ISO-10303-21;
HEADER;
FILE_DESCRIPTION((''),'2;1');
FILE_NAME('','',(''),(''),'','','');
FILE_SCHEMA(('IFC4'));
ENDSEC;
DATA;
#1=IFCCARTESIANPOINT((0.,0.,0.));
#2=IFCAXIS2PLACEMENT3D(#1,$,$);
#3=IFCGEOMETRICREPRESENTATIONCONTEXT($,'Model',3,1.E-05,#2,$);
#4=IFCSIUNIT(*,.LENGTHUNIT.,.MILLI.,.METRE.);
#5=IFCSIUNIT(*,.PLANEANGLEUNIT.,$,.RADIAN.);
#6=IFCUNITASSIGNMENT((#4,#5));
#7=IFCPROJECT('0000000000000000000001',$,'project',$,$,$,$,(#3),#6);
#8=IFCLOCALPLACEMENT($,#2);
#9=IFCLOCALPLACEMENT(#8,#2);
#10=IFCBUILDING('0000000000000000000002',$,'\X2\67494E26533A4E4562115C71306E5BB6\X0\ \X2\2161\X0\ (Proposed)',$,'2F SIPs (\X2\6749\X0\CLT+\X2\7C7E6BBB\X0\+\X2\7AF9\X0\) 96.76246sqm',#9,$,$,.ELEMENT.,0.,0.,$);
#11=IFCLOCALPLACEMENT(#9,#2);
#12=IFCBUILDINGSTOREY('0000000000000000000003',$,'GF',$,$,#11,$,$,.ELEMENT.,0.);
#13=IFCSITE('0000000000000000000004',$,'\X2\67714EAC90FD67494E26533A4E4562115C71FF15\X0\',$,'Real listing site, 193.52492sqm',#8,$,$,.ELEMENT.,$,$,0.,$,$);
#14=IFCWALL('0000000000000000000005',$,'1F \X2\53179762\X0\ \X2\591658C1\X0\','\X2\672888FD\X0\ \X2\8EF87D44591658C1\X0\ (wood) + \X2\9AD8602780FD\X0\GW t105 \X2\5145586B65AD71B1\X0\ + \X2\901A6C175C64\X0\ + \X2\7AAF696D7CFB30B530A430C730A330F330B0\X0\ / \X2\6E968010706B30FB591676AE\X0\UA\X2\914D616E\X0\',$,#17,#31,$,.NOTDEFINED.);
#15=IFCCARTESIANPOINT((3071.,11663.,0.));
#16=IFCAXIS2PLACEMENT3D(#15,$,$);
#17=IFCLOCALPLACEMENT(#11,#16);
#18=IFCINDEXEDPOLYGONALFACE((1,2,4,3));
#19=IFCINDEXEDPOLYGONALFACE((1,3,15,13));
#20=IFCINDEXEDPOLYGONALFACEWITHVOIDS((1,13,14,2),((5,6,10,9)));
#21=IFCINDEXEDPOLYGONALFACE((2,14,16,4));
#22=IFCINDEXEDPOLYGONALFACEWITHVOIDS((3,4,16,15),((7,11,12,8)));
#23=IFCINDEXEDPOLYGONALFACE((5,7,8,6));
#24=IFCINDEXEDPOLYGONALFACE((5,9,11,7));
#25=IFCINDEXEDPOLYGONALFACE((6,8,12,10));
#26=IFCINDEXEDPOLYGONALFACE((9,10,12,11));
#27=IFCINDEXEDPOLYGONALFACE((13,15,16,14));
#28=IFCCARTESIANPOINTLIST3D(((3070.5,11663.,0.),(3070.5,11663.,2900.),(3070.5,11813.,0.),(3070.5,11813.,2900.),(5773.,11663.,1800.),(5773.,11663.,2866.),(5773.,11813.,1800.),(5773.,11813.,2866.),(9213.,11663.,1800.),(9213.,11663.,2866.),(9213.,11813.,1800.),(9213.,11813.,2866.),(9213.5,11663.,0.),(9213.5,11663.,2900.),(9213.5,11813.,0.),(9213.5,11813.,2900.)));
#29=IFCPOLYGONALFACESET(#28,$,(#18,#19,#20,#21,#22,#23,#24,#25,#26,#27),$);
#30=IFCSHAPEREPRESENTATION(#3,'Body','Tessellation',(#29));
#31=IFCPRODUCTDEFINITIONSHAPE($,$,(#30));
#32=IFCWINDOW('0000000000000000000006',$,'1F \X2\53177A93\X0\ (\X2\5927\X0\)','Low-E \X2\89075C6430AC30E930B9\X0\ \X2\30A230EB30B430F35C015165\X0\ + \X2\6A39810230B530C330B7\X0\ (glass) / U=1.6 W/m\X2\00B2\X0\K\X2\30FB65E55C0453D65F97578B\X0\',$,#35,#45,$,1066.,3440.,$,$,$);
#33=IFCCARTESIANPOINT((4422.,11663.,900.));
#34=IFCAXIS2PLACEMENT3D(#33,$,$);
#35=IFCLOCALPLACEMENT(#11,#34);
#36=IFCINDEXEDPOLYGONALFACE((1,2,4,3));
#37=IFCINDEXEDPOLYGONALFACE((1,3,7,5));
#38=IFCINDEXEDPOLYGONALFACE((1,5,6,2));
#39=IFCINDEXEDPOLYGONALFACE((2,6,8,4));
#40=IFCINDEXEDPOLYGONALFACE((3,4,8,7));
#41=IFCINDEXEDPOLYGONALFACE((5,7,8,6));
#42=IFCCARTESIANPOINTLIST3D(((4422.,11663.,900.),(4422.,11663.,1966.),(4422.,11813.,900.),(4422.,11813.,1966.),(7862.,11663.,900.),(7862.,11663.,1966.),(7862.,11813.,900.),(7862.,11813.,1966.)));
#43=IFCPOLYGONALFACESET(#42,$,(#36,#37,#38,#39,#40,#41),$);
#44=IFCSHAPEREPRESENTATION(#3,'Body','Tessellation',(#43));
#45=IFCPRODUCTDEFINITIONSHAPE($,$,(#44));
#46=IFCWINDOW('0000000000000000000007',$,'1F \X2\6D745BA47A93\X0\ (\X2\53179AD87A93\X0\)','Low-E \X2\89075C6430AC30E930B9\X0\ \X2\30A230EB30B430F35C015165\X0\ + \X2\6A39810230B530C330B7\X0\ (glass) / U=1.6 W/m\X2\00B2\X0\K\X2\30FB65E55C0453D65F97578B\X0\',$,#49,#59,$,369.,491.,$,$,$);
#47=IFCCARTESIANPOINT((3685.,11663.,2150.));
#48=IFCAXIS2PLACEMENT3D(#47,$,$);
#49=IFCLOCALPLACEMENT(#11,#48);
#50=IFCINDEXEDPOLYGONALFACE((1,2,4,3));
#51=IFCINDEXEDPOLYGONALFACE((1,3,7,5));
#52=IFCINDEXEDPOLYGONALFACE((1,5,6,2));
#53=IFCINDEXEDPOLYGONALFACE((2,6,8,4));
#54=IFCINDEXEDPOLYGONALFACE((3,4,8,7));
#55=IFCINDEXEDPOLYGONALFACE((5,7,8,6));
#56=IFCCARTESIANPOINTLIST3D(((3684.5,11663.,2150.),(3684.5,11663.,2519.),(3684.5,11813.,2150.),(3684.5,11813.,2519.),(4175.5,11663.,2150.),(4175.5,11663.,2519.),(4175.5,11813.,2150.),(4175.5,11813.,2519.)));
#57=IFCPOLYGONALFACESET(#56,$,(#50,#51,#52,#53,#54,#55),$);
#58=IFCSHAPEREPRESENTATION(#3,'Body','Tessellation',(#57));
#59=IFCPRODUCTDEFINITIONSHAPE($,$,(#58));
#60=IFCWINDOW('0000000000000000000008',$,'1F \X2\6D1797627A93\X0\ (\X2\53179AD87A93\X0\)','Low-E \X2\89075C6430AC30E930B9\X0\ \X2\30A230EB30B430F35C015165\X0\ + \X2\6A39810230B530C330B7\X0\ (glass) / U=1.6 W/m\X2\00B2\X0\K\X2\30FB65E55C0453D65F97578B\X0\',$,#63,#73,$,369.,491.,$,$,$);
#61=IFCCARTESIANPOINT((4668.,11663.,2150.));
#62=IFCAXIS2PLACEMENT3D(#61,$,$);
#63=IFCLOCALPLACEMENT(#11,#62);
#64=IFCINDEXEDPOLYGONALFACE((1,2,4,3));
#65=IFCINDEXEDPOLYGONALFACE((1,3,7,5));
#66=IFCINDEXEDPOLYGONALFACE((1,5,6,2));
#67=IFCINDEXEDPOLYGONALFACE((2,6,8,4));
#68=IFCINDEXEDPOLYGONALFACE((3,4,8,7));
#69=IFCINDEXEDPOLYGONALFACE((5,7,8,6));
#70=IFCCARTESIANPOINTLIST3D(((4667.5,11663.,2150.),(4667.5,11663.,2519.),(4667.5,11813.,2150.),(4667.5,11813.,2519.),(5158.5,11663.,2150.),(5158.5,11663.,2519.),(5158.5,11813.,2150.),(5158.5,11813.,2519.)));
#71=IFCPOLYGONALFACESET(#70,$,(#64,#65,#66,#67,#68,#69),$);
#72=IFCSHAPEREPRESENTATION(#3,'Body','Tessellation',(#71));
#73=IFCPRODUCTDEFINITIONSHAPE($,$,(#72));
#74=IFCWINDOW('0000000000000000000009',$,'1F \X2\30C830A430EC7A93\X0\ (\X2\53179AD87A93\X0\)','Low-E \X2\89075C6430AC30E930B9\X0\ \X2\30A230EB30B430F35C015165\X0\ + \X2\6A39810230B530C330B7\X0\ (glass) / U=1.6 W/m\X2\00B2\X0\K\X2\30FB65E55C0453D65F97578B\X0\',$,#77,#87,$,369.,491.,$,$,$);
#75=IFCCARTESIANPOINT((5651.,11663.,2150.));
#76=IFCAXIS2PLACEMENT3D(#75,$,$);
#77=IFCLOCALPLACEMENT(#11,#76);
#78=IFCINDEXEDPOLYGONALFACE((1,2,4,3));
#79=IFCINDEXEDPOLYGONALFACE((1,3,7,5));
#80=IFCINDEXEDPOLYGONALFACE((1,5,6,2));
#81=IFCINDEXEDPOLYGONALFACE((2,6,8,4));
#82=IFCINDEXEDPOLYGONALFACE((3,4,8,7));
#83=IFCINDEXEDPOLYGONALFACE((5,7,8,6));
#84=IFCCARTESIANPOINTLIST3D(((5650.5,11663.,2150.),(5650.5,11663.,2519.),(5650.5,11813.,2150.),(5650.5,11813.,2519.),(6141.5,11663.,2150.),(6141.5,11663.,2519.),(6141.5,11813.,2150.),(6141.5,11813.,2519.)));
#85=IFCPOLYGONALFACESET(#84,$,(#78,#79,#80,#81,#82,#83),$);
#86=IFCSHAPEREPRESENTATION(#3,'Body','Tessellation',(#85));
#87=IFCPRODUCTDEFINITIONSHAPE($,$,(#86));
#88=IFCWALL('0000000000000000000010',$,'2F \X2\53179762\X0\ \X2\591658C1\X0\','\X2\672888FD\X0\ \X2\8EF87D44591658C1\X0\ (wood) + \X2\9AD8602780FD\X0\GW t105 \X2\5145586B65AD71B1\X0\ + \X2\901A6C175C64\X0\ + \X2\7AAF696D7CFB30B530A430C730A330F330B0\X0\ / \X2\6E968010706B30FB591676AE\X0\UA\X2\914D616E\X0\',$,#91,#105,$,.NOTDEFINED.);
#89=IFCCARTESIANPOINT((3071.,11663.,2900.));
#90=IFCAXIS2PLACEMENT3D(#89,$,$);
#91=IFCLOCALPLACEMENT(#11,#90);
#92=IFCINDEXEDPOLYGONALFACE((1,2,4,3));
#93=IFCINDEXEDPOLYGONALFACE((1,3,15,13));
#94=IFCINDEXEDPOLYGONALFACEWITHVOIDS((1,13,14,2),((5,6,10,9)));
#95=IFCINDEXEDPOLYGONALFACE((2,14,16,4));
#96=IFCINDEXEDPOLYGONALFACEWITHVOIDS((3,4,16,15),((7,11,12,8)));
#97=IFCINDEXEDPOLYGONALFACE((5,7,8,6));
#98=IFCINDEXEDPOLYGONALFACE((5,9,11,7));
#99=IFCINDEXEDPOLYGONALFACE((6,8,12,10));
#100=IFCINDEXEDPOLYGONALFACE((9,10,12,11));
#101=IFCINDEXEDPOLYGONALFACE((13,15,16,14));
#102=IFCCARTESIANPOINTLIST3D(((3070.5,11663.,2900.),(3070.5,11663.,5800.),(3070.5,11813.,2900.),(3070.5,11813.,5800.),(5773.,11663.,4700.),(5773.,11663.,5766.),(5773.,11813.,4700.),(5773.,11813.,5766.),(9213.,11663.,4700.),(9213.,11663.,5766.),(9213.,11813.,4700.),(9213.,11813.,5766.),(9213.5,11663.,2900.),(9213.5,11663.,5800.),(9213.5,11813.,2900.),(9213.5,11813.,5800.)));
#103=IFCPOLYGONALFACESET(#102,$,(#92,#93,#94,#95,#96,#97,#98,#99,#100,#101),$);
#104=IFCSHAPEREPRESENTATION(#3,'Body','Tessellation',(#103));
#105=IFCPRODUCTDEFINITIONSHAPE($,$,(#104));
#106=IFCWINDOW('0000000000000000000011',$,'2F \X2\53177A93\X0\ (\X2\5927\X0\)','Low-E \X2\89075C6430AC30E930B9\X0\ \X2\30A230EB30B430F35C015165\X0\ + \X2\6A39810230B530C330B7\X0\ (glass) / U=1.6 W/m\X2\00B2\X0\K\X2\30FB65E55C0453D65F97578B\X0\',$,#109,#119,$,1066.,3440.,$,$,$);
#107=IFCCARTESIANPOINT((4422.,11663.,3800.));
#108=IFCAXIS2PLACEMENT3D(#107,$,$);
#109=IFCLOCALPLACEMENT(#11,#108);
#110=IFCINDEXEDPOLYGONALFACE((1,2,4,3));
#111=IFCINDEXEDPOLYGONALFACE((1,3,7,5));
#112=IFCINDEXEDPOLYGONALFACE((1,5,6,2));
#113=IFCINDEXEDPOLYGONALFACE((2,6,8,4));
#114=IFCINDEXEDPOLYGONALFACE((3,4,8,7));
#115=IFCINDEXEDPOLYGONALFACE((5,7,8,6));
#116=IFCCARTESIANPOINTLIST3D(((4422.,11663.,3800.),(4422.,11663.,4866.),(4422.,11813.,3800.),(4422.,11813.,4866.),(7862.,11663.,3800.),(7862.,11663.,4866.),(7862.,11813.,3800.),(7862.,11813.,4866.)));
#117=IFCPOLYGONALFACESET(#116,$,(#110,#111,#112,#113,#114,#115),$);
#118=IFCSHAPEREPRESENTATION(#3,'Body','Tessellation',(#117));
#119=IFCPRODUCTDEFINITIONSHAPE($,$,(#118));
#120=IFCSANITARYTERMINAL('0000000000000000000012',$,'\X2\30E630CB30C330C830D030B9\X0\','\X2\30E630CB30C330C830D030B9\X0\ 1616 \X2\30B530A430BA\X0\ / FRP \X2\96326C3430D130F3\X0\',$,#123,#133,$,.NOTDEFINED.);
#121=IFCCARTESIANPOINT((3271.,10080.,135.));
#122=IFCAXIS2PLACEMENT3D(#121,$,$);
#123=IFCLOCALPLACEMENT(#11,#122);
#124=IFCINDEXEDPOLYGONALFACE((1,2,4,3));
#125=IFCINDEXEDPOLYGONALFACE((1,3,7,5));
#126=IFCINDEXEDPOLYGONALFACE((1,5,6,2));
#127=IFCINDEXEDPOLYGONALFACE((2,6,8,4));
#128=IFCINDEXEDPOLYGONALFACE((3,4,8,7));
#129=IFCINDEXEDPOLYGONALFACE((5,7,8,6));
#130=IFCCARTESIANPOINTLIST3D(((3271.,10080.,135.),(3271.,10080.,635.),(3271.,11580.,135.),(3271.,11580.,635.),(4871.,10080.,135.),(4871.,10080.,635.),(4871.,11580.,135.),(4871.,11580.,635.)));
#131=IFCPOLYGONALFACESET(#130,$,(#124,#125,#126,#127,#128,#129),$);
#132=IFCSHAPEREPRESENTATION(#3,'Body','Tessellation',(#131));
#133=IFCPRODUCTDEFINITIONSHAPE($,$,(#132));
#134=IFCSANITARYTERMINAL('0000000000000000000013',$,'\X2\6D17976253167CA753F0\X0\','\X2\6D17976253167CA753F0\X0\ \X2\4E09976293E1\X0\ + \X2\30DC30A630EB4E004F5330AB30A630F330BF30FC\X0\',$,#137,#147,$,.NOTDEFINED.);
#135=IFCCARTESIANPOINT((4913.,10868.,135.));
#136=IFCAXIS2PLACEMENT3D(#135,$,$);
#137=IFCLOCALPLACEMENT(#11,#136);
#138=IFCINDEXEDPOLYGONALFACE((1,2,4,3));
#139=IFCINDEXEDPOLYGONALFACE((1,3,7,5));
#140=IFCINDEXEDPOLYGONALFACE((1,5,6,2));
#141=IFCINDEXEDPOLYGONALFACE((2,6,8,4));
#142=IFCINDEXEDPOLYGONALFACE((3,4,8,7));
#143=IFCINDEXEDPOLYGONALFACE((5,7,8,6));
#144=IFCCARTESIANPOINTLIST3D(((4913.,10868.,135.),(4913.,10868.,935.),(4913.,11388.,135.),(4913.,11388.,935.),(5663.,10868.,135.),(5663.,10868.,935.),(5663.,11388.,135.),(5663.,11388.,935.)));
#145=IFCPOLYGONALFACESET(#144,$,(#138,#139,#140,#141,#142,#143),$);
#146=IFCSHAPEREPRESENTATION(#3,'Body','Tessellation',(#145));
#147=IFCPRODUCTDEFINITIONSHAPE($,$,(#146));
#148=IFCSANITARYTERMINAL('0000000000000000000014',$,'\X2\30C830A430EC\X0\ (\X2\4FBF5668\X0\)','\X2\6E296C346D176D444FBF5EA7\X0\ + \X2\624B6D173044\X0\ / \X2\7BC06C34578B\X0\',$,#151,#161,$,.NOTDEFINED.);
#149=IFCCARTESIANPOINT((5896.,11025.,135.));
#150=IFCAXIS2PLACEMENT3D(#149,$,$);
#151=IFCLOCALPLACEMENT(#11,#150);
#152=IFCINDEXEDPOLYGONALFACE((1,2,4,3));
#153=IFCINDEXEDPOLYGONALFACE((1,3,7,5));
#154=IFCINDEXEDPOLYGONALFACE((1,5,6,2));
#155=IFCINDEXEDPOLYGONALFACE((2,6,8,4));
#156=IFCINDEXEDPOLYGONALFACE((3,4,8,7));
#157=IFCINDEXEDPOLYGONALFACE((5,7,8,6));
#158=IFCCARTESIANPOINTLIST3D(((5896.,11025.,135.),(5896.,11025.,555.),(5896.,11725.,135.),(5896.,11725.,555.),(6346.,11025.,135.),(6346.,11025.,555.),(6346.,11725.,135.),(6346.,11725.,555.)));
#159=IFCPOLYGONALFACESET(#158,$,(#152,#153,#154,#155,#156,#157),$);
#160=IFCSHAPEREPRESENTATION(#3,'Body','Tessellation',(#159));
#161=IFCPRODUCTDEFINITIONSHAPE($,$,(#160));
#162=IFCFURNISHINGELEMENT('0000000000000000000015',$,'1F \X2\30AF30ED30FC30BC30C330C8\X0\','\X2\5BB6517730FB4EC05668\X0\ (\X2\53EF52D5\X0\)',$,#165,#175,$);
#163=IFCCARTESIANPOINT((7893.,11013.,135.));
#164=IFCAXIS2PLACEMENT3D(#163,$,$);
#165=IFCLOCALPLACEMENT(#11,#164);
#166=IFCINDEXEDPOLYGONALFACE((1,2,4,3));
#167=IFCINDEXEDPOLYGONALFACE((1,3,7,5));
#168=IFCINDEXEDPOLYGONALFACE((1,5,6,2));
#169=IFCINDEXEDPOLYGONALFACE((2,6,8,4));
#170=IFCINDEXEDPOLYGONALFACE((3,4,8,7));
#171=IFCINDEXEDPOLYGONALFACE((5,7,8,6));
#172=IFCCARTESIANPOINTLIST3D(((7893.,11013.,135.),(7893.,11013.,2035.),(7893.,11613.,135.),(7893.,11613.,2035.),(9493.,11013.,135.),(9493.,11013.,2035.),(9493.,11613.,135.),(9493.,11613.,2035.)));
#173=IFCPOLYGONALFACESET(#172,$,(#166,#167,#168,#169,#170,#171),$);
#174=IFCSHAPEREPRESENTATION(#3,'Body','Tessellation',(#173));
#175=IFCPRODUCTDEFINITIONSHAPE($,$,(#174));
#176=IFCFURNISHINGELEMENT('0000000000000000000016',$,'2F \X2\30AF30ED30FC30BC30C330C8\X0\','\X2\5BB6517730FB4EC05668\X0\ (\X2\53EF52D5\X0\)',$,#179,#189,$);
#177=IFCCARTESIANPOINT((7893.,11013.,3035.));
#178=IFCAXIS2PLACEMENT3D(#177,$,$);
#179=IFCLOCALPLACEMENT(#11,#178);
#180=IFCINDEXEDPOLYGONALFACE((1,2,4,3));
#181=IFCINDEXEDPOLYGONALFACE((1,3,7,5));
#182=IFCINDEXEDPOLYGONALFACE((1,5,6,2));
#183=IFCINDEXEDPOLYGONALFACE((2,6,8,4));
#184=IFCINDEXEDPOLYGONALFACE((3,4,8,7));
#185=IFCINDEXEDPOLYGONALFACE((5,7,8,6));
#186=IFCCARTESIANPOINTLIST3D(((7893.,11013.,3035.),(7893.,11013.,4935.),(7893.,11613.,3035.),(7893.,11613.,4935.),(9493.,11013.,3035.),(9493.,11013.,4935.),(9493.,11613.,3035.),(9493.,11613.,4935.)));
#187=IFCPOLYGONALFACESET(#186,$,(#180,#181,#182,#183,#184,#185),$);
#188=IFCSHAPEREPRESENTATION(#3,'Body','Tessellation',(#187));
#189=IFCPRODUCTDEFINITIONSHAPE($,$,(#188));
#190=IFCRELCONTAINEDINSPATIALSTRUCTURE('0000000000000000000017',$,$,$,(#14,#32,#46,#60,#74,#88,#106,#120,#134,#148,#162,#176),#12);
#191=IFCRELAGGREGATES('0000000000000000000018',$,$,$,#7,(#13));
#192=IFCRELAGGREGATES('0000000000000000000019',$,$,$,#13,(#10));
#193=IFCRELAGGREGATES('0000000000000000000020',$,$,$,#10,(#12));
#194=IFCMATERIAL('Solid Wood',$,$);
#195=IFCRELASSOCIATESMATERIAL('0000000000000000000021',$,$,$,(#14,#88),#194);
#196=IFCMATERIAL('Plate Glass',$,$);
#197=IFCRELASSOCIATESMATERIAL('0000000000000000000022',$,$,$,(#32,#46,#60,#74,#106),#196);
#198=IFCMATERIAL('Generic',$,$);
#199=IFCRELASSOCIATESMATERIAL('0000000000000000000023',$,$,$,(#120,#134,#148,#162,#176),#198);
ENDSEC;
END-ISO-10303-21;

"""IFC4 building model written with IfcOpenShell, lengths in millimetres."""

from ifc_helpers import new_model, si_unit, frame, frame_2d, origin, place, context, project, spatial, rectangle, extrude, material, element, fill, save


model = new_model("IFC4")

# Units and contexts
model_context = context("Model", 3, precision=1e-05, world=origin())
ifc_project = project(units=[si_unit("LENGTHUNIT", "METRE", prefix="MILLI"), si_unit("PLANEANGLEUNIT", "RADIAN")], contexts=[model_context])

# Site, building, storey
site_placement = place(None, origin())
site = spatial("IfcSite", under=ifc_project, at=site_placement, Name="東京都杉並区久我山５", ObjectType="Real listing site, 193.52492sqm", CompositionType="ELEMENT", RefElevation=0.0)
building_placement = place(site_placement, origin())
building = spatial("IfcBuilding", under=site, at=building_placement, Name="杉並区久我山の家 Ⅱ (Proposed)", ObjectType="2F SIPs (杉CLT+籾殻+竹) 96.76246sqm", CompositionType="ELEMENT", ElevationOfRefHeight=0.0, ElevationOfTerrain=0.0)
storey_placement = place(building_placement, origin())
storey = spatial("IfcBuildingStorey", under=building, at=storey_placement, Name="GF", CompositionType="ELEMENT", Elevation=0.0)

# Wall, openings, windows
ifc_material_1 = material(Name="Solid Wood")
wall_1_placement = place(storey_placement, frame((3071.0, 11663.0, 0.0)))
wall_1 = element("IfcWall", 1, at=wall_1_placement, inside=storey, material=ifc_material_1, Name="1F 北面 外壁", Description="木製 軸組外壁 (wood) + 高性能GW t105 充填断熱 + 通気層 + 窯業系サイディング / 準耐火・外皮UA配慮", PredefinedType="NOTDEFINED", context=model_context, shape_type="SweptSolid", body=[
    extrude(rectangle(XDim=6143.0, YDim=150.0, at=frame_2d((3071.0, 75.0))), frame((3071.0, 11663.0, 0.0)), (0.0, 0.0, 1.0), 2900.0),
])
opening_1_placement = place(storey_placement, frame((4422.0, 11663.0, 900.0)))
opening_1 = element("IfcOpeningElement", 2, at=opening_1_placement, cuts=wall_1, PredefinedType="NOTDEFINED", context=model_context, shape_type="SweptSolid", body=[
    extrude(rectangle(XDim=3440.0, YDim=150.0, at=frame_2d((1720.0, 75.0))), frame((4422.0, 11663.0, 900.0)), (0.0, 0.0, 1.0), 1066.0),
])
opening_2_placement = place(storey_placement, frame((3685.0, 11663.0, 2150.0)))
opening_2 = element("IfcOpeningElement", 3, at=opening_2_placement, cuts=wall_1, PredefinedType="NOTDEFINED", context=model_context, shape_type="SweptSolid", body=[
    extrude(rectangle(XDim=491.0, YDim=150.0, at=frame_2d((245.0, 75.0))), frame((3685.0, 11663.0, 2150.0)), (0.0, 0.0, 1.0), 369.0),
])
opening_3_placement = place(storey_placement, frame((4668.0, 11663.0, 2150.0)))
opening_3 = element("IfcOpeningElement", 4, at=opening_3_placement, cuts=wall_1, PredefinedType="NOTDEFINED", context=model_context, shape_type="SweptSolid", body=[
    extrude(rectangle(XDim=491.0, YDim=150.0, at=frame_2d((245.0, 75.0))), frame((4668.0, 11663.0, 2150.0)), (0.0, 0.0, 1.0), 369.0),
])
opening_4_placement = place(storey_placement, frame((5651.0, 11663.0, 2150.0)))
opening_4 = element("IfcOpeningElement", 5, at=opening_4_placement, cuts=wall_1, PredefinedType="NOTDEFINED", context=model_context, shape_type="SweptSolid", body=[
    extrude(rectangle(XDim=491.0, YDim=150.0, at=frame_2d((245.0, 75.0))), frame((5651.0, 11663.0, 2150.0)), (0.0, 0.0, 1.0), 369.0),
])
ifc_material_2 = material(Name="Plate Glass")
window_1_placement = place(storey_placement, frame((4422.0, 11663.0, 900.0)))
window_1 = element("IfcWindow", 6, at=window_1_placement, inside=storey, material=ifc_material_2, Name="1F 北窓 (大)", Description="Low-E 複層ガラス アルゴン封入 + 樹脂サッシ (glass) / U=1.6 W/m²K・日射取得型", OverallHeight=1066.0, OverallWidth=3440.0, context=model_context, shape_type="SweptSolid", body=[
    extrude(rectangle(XDim=3440.0, YDim=150.0, at=frame_2d((1720.0, 75.0))), frame((4422.0, 11663.0, 900.0)), (0.0, 0.0, 1.0), 1066.0),
])
fill(opening_1, window_1)
window_2_placement = place(storey_placement, frame((3685.0, 11663.0, 2150.0)))
window_2 = element("IfcWindow", 7, at=window_2_placement, inside=storey, material=ifc_material_2, Name="1F 浴室窓 (北高窓)", Description="Low-E 複層ガラス アルゴン封入 + 樹脂サッシ (glass) / U=1.6 W/m²K・日射取得型", OverallHeight=369.0, OverallWidth=491.0, context=model_context, shape_type="SweptSolid", body=[
    extrude(rectangle(XDim=491.0, YDim=150.0, at=frame_2d((245.0, 75.0))), frame((3685.0, 11663.0, 2150.0)), (0.0, 0.0, 1.0), 369.0),
])
fill(opening_2, window_2)
window_3_placement = place(storey_placement, frame((4668.0, 11663.0, 2150.0)))
window_3 = element("IfcWindow", 8, at=window_3_placement, inside=storey, material=ifc_material_2, Name="1F 洗面窓 (北高窓)", Description="Low-E 複層ガラス アルゴン封入 + 樹脂サッシ (glass) / U=1.6 W/m²K・日射取得型", OverallHeight=369.0, OverallWidth=491.0, context=model_context, shape_type="SweptSolid", body=[
    extrude(rectangle(XDim=491.0, YDim=150.0, at=frame_2d((245.0, 75.0))), frame((4668.0, 11663.0, 2150.0)), (0.0, 0.0, 1.0), 369.0),
])
fill(opening_3, window_3)
window_4_placement = place(storey_placement, frame((5651.0, 11663.0, 2150.0)))
window_4 = element("IfcWindow", 9, at=window_4_placement, inside=storey, material=ifc_material_2, Name="1F トイレ窓 (北高窓)", Description="Low-E 複層ガラス アルゴン封入 + 樹脂サッシ (glass) / U=1.6 W/m²K・日射取得型", OverallHeight=369.0, OverallWidth=491.0, context=model_context, shape_type="SweptSolid", body=[
    extrude(rectangle(XDim=491.0, YDim=150.0, at=frame_2d((245.0, 75.0))), frame((5651.0, 11663.0, 2150.0)), (0.0, 0.0, 1.0), 369.0),
])
fill(opening_4, window_4)

# Wall, opening, window
wall_2_placement = place(storey_placement, frame((3071.0, 11663.0, 2900.0)))
wall_2 = element("IfcWall", 10, at=wall_2_placement, inside=storey, material=ifc_material_1, Name="2F 北面 外壁", Description="木製 軸組外壁 (wood) + 高性能GW t105 充填断熱 + 通気層 + 窯業系サイディング / 準耐火・外皮UA配慮", PredefinedType="NOTDEFINED", context=model_context, shape_type="SweptSolid", body=[
    extrude(rectangle(XDim=6143.0, YDim=150.0, at=frame_2d((3071.0, 75.0))), frame((3071.0, 11663.0, 2900.0)), (0.0, 0.0, 1.0), 2900.0),
])
opening_5_placement = place(storey_placement, frame((4422.0, 11663.0, 3800.0)))
opening_5 = element("IfcOpeningElement", 11, at=opening_5_placement, cuts=wall_2, PredefinedType="NOTDEFINED", context=model_context, shape_type="SweptSolid", body=[
    extrude(rectangle(XDim=3440.0, YDim=150.0, at=frame_2d((1720.0, 75.0))), frame((4422.0, 11663.0, 3800.0)), (0.0, 0.0, 1.0), 1066.0),
])
window_5_placement = place(storey_placement, frame((4422.0, 11663.0, 3800.0)))
window_5 = element("IfcWindow", 12, at=window_5_placement, inside=storey, material=ifc_material_2, Name="2F 北窓 (大)", Description="Low-E 複層ガラス アルゴン封入 + 樹脂サッシ (glass) / U=1.6 W/m²K・日射取得型", OverallHeight=1066.0, OverallWidth=3440.0, context=model_context, shape_type="SweptSolid", body=[
    extrude(rectangle(XDim=3440.0, YDim=150.0, at=frame_2d((1720.0, 75.0))), frame((4422.0, 11663.0, 3800.0)), (0.0, 0.0, 1.0), 1066.0),
])
fill(opening_5, window_5)

# Sanitary terminals
ifc_material_3 = material(Name="Generic")
sanitary_terminal_1_placement = place(storey_placement, frame((3271.0, 10080.0, 135.0)))
element("IfcSanitaryTerminal", 13, at=sanitary_terminal_1_placement, inside=storey, material=ifc_material_3, Name="ユニットバス", Description="ユニットバス 1616 サイズ / FRP 防水パン", PredefinedType="NOTDEFINED", context=model_context, shape_type="SweptSolid", body=[
    extrude(rectangle(XDim=1600.0, YDim=1500.0, at=frame_2d((800.0, 750.0))), frame((3271.0, 10080.0, 135.0)), (0.0, 0.0, 1.0), 500.0),
])
sanitary_terminal_2_placement = place(storey_placement, frame((4913.0, 10868.0, 135.0)))
element("IfcSanitaryTerminal", 14, at=sanitary_terminal_2_placement, inside=storey, material=ifc_material_3, Name="洗面化粧台", Description="洗面化粧台 三面鏡 + ボウル一体カウンター", PredefinedType="NOTDEFINED", context=model_context, shape_type="SweptSolid", body=[
    extrude(rectangle(XDim=750.0, YDim=520.0, at=frame_2d((375.0, 260.0))), frame((4913.0, 10868.0, 135.0)), (0.0, 0.0, 1.0), 800.0),
])
sanitary_terminal_3_placement = place(storey_placement, frame((5896.0, 11025.0, 135.0)))
element("IfcSanitaryTerminal", 15, at=sanitary_terminal_3_placement, inside=storey, material=ifc_material_3, Name="トイレ (便器)", Description="温水洗浄便座 + 手洗い / 節水型", PredefinedType="NOTDEFINED", context=model_context, shape_type="SweptSolid", body=[
    extrude(rectangle(XDim=450.0, YDim=700.0, at=frame_2d((225.0, 350.0))), frame((5896.0, 11025.0, 135.0)), (0.0, 0.0, 1.0), 420.0),
])

# Furnishing elements
furnishing_1_placement = place(storey_placement, frame((7893.0, 11013.0, 135.0)))
element("IfcFurnishingElement", 16, at=furnishing_1_placement, inside=storey, material=ifc_material_3, Name="1F クローゼット", Description="家具・什器 (可動)", context=model_context, shape_type="SweptSolid", body=[
    extrude(rectangle(XDim=1600.0, YDim=600.0, at=frame_2d((800.0, 300.0))), frame((7893.0, 11013.0, 135.0)), (0.0, 0.0, 1.0), 1900.0),
])
furnishing_2_placement = place(storey_placement, frame((7893.0, 11013.0, 3035.0)))
element("IfcFurnishingElement", 17, at=furnishing_2_placement, inside=storey, material=ifc_material_3, Name="2F クローゼット", Description="家具・什器 (可動)", context=model_context, shape_type="SweptSolid", body=[
    extrude(rectangle(XDim=1600.0, YDim=600.0, at=frame_2d((800.0, 300.0))), frame((7893.0, 11013.0, 3035.0)), (0.0, 0.0, 1.0), 1900.0),
])

save(model, "model.ifc")
